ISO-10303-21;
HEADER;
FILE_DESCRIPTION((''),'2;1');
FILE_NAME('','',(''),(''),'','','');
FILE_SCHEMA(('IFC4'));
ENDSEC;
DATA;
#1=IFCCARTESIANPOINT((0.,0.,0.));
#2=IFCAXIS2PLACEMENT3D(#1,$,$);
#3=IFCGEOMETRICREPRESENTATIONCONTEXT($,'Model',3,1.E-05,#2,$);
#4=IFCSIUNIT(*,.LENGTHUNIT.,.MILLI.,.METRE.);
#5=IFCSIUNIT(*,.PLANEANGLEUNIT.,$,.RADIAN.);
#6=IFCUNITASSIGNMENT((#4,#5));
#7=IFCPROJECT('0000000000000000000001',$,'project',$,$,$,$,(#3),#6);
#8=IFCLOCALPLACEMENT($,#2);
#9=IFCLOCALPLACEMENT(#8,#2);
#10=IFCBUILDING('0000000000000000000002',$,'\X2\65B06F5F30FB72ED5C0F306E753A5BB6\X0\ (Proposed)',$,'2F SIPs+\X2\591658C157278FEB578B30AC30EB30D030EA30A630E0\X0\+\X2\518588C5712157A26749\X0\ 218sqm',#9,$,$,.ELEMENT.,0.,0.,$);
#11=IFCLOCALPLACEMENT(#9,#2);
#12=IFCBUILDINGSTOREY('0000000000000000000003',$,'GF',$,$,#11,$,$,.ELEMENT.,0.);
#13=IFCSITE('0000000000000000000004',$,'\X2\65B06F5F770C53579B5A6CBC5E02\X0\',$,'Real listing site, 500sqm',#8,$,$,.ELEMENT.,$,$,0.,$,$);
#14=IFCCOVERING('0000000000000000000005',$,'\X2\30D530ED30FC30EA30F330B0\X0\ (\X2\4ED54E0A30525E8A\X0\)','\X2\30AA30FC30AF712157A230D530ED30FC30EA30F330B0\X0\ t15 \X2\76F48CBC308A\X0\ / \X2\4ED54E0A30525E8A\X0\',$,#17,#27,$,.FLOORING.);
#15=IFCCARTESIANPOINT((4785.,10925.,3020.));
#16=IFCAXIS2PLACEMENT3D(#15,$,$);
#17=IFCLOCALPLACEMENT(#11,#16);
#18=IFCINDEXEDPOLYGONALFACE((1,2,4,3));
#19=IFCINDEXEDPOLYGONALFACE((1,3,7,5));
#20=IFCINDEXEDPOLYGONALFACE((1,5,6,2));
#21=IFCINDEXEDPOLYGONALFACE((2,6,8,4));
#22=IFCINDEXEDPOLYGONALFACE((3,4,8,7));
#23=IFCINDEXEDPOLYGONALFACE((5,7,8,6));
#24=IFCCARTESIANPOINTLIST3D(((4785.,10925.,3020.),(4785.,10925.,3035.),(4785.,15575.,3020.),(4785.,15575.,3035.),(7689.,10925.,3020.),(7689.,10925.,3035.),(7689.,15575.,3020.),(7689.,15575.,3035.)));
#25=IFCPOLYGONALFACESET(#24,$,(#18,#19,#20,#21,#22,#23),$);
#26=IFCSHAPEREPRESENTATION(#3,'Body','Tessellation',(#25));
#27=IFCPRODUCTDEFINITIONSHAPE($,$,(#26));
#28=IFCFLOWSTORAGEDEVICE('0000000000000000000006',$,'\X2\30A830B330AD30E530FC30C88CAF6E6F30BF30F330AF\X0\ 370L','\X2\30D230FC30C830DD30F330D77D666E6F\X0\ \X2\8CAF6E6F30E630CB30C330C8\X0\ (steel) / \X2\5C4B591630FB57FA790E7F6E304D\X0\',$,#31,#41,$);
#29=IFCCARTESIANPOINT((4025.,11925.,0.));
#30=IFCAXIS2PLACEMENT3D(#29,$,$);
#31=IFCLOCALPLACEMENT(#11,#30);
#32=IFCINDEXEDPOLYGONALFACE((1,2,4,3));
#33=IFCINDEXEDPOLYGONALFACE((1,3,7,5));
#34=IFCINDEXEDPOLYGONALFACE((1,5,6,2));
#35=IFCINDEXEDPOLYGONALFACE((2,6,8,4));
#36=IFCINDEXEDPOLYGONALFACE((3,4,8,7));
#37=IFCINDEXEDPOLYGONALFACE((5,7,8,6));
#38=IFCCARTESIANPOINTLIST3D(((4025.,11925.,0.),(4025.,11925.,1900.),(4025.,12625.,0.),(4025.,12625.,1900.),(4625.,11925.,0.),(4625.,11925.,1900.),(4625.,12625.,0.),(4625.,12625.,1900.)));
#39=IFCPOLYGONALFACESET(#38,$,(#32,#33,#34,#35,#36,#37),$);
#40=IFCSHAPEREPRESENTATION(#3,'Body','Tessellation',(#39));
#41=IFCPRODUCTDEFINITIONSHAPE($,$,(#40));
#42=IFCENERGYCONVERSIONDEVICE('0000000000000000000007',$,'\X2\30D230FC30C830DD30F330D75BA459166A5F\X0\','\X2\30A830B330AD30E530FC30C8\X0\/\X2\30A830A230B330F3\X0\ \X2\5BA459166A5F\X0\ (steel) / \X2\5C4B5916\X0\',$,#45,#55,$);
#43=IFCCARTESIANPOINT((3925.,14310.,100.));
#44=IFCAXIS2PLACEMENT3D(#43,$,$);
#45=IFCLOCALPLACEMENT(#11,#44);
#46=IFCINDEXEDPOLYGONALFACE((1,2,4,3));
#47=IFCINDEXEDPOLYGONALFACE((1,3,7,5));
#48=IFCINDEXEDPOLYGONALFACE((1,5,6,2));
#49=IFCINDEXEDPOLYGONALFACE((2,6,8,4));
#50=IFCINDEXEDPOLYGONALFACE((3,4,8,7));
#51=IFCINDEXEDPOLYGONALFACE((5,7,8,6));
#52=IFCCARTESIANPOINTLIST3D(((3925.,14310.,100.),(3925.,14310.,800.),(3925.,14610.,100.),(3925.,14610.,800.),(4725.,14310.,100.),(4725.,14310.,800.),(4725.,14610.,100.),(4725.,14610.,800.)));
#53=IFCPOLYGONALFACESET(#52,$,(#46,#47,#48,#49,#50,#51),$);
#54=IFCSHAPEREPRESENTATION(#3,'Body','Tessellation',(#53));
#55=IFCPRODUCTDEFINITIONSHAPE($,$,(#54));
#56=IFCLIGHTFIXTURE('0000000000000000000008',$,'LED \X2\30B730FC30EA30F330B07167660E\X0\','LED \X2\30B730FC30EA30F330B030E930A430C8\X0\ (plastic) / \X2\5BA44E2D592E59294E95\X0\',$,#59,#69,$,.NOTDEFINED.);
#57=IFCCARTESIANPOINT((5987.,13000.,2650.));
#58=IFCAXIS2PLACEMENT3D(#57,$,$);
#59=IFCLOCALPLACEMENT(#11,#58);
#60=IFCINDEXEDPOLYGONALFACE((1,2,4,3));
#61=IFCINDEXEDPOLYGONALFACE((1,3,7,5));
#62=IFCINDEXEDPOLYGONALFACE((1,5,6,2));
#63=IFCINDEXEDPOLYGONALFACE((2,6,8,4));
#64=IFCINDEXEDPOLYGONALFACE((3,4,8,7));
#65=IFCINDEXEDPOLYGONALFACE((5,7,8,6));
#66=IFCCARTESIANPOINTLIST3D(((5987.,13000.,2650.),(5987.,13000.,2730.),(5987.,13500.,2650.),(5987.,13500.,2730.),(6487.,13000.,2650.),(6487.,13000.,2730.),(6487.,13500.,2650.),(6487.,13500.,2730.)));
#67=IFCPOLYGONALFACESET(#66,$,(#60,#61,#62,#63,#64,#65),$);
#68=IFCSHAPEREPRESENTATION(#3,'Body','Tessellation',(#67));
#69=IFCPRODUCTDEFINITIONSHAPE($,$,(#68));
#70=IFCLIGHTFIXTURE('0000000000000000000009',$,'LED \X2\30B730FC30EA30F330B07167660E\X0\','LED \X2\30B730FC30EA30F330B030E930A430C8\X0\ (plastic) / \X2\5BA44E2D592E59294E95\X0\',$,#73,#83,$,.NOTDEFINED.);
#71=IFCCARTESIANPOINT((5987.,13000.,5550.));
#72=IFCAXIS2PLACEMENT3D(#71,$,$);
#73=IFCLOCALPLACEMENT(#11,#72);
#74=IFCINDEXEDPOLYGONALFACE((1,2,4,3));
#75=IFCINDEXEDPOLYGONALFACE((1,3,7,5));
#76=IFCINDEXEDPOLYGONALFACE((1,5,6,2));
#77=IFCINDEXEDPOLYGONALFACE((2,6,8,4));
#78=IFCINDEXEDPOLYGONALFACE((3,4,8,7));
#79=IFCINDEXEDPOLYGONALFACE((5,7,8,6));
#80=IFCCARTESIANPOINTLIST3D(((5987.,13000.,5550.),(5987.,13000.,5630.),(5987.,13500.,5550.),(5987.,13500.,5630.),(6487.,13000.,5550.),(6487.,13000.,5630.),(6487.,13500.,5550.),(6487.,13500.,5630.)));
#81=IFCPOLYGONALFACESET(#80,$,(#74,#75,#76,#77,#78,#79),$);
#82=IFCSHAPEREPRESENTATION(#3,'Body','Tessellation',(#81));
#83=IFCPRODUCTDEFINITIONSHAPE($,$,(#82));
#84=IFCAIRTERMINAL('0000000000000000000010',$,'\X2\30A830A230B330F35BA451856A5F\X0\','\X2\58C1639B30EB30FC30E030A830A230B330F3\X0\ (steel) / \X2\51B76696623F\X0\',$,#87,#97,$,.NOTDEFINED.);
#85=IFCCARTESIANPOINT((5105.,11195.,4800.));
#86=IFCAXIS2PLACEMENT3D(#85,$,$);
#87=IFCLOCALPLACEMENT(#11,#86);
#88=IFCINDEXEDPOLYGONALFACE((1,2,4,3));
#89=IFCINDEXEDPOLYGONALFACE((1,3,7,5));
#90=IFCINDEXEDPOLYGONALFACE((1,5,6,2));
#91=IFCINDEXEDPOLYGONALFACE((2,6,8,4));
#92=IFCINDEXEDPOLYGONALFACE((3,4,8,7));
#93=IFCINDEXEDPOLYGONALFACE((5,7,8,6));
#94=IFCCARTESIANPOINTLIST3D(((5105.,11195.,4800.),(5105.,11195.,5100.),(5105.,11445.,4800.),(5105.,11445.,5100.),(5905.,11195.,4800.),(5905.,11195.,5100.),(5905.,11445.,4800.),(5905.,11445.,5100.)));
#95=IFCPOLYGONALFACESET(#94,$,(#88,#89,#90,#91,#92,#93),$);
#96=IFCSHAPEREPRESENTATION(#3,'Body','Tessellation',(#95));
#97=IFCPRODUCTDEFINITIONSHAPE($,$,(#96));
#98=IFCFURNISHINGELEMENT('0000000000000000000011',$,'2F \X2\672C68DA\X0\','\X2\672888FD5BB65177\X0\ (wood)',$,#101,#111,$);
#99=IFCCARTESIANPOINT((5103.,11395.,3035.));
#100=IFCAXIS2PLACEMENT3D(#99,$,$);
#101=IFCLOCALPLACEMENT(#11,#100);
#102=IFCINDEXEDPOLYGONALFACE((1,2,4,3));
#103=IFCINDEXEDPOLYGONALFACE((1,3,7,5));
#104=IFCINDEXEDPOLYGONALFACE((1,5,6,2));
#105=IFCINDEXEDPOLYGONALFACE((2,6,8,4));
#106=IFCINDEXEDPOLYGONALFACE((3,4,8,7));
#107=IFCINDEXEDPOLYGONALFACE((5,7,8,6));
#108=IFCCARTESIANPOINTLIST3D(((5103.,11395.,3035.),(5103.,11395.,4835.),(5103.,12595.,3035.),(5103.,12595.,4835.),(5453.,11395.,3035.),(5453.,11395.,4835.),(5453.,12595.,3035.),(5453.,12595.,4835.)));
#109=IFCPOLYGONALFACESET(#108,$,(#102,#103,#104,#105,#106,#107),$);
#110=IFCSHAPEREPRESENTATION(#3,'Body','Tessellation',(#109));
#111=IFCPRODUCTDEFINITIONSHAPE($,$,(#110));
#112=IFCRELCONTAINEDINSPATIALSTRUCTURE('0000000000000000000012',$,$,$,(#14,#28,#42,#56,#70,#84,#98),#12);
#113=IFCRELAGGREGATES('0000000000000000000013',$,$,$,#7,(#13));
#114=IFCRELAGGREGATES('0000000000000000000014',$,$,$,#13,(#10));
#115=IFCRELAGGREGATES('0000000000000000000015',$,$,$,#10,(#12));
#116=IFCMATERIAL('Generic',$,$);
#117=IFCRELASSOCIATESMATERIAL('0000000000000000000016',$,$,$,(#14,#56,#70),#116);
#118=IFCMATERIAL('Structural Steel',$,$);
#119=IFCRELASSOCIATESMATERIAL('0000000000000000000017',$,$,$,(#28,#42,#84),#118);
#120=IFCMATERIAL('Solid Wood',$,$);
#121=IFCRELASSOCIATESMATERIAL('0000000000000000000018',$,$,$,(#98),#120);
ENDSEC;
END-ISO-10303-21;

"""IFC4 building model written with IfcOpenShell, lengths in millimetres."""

from ifc_helpers import new_model, si_unit, frame, frame_2d, origin, place, context, project, spatial, rectangle, extrude, material, element, save


model = new_model("IFC4")

# Units and contexts
model_context = context("Model", 3, precision=1e-05, world=origin())
ifc_project = project(units=[si_unit("LENGTHUNIT", "METRE", prefix="MILLI"), si_unit("PLANEANGLEUNIT", "RADIAN")], contexts=[model_context])

# Site, building, storey
site_placement = place(None, origin())
site = spatial("IfcSite", under=ifc_project, at=site_placement, Name="新潟県南魚沼市", ObjectType="Real listing site, 500sqm", CompositionType="ELEMENT", RefElevation=0.0)
building_placement = place(site_placement, origin())
building = spatial("IfcBuilding", under=site, at=building_placement, Name="新潟・狭小の町家 (Proposed)", ObjectType="2F SIPs+外壁圧迫型ガルバリウム+内装無垢杉 218sqm", CompositionType="ELEMENT", ElevationOfRefHeight=0.0, ElevationOfTerrain=0.0)
storey_placement = place(building_placement, origin())
storey = spatial("IfcBuildingStorey", under=building, at=storey_placement, Name="GF", CompositionType="ELEMENT", Elevation=0.0)

# Shared definitions
ifc_material_1 = material(Name="Solid Wood")

# Shared definitions
ifc_material_2 = material(Name="Structural Steel")

# Covering
ifc_material_3 = material(Name="Generic")
covering_1_placement = place(storey_placement, frame((4785.0, 10925.0, 3020.0)))
element("IfcCovering", 1, at=covering_1_placement, inside=storey, material=ifc_material_3, Name="フローリング (仕上げ床)", Description="オーク無垢フローリング t15 直貼り / 仕上げ床", PredefinedType="FLOORING", context=model_context, shape_type="SweptSolid", body=[
    extrude(rectangle(XDim=2904.0, YDim=4650.0, at=frame_2d((1452.0, 2325.0))), frame((4785.0, 10925.0, 3020.0)), (0.0, 0.0, 1.0), 15.0),
])

# Flow storage device
flow_storage_device_placement = place(storey_placement, frame((4025.0, 11925.0, 0.0)))
element("IfcFlowStorageDevice", 2, at=flow_storage_device_placement, inside=storey, material=ifc_material_2, Name="エコキュート貯湯タンク 370L", Description="ヒートポンプ給湯 貯湯ユニット (steel) / 屋外・基礎置き", context=model_context, shape_type="SweptSolid", body=[
    extrude(rectangle(XDim=600.0, YDim=700.0, at=frame_2d((300.0, 350.0))), frame((4025.0, 11925.0, 0.0)), (0.0, 0.0, 1.0), 1900.0),
])

# Energy conversion device
energy_conversion_device_placement = place(storey_placement, frame((3925.0, 14310.0, 100.0)))
element("IfcEnergyConversionDevice", 3, at=energy_conversion_device_placement, inside=storey, material=ifc_material_2, Name="ヒートポンプ室外機", Description="エコキュート/エアコン 室外機 (steel) / 屋外", context=model_context, shape_type="SweptSolid", body=[
    extrude(rectangle(XDim=800.0, YDim=300.0, at=frame_2d((400.0, 150.0))), frame((3925.0, 14310.0, 100.0)), (0.0, 0.0, 1.0), 700.0),
])

# Light fixtures
light_fixture_1_placement = place(storey_placement, frame((5987.0, 13000.0, 2650.0)))
element("IfcLightFixture", 4, at=light_fixture_1_placement, inside=storey, material=ifc_material_3, Name="LED シーリング照明", Description="LED シーリングライト (plastic) / 室中央天井", PredefinedType="NOTDEFINED", context=model_context, shape_type="SweptSolid", body=[
    extrude(rectangle(XDim=500.0, YDim=500.0, at=frame_2d((250.0, 250.0))), frame((5987.0, 13000.0, 2650.0)), (0.0, 0.0, 1.0), 80.0),
])
light_fixture_2_placement = place(storey_placement, frame((5987.0, 13000.0, 5550.0)))
element("IfcLightFixture", 5, at=light_fixture_2_placement, inside=storey, material=ifc_material_3, Name="LED シーリング照明", Description="LED シーリングライト (plastic) / 室中央天井", PredefinedType="NOTDEFINED", context=model_context, shape_type="SweptSolid", body=[
    extrude(rectangle(XDim=500.0, YDim=500.0, at=frame_2d((250.0, 250.0))), frame((5987.0, 13000.0, 5550.0)), (0.0, 0.0, 1.0), 80.0),
])

# Air terminal
air_terminal_placement = place(storey_placement, frame((5105.0, 11195.0, 4800.0)))
element("IfcAirTerminal", 6, at=air_terminal_placement, inside=storey, material=ifc_material_2, Name="エアコン室内機", Description="壁掛ルームエアコン (steel) / 冷暖房", PredefinedType="NOTDEFINED", context=model_context, shape_type="SweptSolid", body=[
    extrude(rectangle(XDim=800.0, YDim=250.0, at=frame_2d((400.0, 125.0))), frame((5105.0, 11195.0, 4800.0)), (0.0, 0.0, 1.0), 300.0),
])

# Furnishing element
furnishing_placement = place(storey_placement, frame((5103.0, 11395.0, 3035.0)))
element("IfcFurnishingElement", 7, at=furnishing_placement, inside=storey, material=ifc_material_1, Name="2F 本棚", Description="木製家具 (wood)", context=model_context, shape_type="SweptSolid", body=[
    extrude(rectangle(XDim=350.0, YDim=1200.0, at=frame_2d((175.0, 600.0))), frame((5103.0, 11395.0, 3035.0)), (0.0, 0.0, 1.0), 1800.0),
])

save(model, "model.ifc")
